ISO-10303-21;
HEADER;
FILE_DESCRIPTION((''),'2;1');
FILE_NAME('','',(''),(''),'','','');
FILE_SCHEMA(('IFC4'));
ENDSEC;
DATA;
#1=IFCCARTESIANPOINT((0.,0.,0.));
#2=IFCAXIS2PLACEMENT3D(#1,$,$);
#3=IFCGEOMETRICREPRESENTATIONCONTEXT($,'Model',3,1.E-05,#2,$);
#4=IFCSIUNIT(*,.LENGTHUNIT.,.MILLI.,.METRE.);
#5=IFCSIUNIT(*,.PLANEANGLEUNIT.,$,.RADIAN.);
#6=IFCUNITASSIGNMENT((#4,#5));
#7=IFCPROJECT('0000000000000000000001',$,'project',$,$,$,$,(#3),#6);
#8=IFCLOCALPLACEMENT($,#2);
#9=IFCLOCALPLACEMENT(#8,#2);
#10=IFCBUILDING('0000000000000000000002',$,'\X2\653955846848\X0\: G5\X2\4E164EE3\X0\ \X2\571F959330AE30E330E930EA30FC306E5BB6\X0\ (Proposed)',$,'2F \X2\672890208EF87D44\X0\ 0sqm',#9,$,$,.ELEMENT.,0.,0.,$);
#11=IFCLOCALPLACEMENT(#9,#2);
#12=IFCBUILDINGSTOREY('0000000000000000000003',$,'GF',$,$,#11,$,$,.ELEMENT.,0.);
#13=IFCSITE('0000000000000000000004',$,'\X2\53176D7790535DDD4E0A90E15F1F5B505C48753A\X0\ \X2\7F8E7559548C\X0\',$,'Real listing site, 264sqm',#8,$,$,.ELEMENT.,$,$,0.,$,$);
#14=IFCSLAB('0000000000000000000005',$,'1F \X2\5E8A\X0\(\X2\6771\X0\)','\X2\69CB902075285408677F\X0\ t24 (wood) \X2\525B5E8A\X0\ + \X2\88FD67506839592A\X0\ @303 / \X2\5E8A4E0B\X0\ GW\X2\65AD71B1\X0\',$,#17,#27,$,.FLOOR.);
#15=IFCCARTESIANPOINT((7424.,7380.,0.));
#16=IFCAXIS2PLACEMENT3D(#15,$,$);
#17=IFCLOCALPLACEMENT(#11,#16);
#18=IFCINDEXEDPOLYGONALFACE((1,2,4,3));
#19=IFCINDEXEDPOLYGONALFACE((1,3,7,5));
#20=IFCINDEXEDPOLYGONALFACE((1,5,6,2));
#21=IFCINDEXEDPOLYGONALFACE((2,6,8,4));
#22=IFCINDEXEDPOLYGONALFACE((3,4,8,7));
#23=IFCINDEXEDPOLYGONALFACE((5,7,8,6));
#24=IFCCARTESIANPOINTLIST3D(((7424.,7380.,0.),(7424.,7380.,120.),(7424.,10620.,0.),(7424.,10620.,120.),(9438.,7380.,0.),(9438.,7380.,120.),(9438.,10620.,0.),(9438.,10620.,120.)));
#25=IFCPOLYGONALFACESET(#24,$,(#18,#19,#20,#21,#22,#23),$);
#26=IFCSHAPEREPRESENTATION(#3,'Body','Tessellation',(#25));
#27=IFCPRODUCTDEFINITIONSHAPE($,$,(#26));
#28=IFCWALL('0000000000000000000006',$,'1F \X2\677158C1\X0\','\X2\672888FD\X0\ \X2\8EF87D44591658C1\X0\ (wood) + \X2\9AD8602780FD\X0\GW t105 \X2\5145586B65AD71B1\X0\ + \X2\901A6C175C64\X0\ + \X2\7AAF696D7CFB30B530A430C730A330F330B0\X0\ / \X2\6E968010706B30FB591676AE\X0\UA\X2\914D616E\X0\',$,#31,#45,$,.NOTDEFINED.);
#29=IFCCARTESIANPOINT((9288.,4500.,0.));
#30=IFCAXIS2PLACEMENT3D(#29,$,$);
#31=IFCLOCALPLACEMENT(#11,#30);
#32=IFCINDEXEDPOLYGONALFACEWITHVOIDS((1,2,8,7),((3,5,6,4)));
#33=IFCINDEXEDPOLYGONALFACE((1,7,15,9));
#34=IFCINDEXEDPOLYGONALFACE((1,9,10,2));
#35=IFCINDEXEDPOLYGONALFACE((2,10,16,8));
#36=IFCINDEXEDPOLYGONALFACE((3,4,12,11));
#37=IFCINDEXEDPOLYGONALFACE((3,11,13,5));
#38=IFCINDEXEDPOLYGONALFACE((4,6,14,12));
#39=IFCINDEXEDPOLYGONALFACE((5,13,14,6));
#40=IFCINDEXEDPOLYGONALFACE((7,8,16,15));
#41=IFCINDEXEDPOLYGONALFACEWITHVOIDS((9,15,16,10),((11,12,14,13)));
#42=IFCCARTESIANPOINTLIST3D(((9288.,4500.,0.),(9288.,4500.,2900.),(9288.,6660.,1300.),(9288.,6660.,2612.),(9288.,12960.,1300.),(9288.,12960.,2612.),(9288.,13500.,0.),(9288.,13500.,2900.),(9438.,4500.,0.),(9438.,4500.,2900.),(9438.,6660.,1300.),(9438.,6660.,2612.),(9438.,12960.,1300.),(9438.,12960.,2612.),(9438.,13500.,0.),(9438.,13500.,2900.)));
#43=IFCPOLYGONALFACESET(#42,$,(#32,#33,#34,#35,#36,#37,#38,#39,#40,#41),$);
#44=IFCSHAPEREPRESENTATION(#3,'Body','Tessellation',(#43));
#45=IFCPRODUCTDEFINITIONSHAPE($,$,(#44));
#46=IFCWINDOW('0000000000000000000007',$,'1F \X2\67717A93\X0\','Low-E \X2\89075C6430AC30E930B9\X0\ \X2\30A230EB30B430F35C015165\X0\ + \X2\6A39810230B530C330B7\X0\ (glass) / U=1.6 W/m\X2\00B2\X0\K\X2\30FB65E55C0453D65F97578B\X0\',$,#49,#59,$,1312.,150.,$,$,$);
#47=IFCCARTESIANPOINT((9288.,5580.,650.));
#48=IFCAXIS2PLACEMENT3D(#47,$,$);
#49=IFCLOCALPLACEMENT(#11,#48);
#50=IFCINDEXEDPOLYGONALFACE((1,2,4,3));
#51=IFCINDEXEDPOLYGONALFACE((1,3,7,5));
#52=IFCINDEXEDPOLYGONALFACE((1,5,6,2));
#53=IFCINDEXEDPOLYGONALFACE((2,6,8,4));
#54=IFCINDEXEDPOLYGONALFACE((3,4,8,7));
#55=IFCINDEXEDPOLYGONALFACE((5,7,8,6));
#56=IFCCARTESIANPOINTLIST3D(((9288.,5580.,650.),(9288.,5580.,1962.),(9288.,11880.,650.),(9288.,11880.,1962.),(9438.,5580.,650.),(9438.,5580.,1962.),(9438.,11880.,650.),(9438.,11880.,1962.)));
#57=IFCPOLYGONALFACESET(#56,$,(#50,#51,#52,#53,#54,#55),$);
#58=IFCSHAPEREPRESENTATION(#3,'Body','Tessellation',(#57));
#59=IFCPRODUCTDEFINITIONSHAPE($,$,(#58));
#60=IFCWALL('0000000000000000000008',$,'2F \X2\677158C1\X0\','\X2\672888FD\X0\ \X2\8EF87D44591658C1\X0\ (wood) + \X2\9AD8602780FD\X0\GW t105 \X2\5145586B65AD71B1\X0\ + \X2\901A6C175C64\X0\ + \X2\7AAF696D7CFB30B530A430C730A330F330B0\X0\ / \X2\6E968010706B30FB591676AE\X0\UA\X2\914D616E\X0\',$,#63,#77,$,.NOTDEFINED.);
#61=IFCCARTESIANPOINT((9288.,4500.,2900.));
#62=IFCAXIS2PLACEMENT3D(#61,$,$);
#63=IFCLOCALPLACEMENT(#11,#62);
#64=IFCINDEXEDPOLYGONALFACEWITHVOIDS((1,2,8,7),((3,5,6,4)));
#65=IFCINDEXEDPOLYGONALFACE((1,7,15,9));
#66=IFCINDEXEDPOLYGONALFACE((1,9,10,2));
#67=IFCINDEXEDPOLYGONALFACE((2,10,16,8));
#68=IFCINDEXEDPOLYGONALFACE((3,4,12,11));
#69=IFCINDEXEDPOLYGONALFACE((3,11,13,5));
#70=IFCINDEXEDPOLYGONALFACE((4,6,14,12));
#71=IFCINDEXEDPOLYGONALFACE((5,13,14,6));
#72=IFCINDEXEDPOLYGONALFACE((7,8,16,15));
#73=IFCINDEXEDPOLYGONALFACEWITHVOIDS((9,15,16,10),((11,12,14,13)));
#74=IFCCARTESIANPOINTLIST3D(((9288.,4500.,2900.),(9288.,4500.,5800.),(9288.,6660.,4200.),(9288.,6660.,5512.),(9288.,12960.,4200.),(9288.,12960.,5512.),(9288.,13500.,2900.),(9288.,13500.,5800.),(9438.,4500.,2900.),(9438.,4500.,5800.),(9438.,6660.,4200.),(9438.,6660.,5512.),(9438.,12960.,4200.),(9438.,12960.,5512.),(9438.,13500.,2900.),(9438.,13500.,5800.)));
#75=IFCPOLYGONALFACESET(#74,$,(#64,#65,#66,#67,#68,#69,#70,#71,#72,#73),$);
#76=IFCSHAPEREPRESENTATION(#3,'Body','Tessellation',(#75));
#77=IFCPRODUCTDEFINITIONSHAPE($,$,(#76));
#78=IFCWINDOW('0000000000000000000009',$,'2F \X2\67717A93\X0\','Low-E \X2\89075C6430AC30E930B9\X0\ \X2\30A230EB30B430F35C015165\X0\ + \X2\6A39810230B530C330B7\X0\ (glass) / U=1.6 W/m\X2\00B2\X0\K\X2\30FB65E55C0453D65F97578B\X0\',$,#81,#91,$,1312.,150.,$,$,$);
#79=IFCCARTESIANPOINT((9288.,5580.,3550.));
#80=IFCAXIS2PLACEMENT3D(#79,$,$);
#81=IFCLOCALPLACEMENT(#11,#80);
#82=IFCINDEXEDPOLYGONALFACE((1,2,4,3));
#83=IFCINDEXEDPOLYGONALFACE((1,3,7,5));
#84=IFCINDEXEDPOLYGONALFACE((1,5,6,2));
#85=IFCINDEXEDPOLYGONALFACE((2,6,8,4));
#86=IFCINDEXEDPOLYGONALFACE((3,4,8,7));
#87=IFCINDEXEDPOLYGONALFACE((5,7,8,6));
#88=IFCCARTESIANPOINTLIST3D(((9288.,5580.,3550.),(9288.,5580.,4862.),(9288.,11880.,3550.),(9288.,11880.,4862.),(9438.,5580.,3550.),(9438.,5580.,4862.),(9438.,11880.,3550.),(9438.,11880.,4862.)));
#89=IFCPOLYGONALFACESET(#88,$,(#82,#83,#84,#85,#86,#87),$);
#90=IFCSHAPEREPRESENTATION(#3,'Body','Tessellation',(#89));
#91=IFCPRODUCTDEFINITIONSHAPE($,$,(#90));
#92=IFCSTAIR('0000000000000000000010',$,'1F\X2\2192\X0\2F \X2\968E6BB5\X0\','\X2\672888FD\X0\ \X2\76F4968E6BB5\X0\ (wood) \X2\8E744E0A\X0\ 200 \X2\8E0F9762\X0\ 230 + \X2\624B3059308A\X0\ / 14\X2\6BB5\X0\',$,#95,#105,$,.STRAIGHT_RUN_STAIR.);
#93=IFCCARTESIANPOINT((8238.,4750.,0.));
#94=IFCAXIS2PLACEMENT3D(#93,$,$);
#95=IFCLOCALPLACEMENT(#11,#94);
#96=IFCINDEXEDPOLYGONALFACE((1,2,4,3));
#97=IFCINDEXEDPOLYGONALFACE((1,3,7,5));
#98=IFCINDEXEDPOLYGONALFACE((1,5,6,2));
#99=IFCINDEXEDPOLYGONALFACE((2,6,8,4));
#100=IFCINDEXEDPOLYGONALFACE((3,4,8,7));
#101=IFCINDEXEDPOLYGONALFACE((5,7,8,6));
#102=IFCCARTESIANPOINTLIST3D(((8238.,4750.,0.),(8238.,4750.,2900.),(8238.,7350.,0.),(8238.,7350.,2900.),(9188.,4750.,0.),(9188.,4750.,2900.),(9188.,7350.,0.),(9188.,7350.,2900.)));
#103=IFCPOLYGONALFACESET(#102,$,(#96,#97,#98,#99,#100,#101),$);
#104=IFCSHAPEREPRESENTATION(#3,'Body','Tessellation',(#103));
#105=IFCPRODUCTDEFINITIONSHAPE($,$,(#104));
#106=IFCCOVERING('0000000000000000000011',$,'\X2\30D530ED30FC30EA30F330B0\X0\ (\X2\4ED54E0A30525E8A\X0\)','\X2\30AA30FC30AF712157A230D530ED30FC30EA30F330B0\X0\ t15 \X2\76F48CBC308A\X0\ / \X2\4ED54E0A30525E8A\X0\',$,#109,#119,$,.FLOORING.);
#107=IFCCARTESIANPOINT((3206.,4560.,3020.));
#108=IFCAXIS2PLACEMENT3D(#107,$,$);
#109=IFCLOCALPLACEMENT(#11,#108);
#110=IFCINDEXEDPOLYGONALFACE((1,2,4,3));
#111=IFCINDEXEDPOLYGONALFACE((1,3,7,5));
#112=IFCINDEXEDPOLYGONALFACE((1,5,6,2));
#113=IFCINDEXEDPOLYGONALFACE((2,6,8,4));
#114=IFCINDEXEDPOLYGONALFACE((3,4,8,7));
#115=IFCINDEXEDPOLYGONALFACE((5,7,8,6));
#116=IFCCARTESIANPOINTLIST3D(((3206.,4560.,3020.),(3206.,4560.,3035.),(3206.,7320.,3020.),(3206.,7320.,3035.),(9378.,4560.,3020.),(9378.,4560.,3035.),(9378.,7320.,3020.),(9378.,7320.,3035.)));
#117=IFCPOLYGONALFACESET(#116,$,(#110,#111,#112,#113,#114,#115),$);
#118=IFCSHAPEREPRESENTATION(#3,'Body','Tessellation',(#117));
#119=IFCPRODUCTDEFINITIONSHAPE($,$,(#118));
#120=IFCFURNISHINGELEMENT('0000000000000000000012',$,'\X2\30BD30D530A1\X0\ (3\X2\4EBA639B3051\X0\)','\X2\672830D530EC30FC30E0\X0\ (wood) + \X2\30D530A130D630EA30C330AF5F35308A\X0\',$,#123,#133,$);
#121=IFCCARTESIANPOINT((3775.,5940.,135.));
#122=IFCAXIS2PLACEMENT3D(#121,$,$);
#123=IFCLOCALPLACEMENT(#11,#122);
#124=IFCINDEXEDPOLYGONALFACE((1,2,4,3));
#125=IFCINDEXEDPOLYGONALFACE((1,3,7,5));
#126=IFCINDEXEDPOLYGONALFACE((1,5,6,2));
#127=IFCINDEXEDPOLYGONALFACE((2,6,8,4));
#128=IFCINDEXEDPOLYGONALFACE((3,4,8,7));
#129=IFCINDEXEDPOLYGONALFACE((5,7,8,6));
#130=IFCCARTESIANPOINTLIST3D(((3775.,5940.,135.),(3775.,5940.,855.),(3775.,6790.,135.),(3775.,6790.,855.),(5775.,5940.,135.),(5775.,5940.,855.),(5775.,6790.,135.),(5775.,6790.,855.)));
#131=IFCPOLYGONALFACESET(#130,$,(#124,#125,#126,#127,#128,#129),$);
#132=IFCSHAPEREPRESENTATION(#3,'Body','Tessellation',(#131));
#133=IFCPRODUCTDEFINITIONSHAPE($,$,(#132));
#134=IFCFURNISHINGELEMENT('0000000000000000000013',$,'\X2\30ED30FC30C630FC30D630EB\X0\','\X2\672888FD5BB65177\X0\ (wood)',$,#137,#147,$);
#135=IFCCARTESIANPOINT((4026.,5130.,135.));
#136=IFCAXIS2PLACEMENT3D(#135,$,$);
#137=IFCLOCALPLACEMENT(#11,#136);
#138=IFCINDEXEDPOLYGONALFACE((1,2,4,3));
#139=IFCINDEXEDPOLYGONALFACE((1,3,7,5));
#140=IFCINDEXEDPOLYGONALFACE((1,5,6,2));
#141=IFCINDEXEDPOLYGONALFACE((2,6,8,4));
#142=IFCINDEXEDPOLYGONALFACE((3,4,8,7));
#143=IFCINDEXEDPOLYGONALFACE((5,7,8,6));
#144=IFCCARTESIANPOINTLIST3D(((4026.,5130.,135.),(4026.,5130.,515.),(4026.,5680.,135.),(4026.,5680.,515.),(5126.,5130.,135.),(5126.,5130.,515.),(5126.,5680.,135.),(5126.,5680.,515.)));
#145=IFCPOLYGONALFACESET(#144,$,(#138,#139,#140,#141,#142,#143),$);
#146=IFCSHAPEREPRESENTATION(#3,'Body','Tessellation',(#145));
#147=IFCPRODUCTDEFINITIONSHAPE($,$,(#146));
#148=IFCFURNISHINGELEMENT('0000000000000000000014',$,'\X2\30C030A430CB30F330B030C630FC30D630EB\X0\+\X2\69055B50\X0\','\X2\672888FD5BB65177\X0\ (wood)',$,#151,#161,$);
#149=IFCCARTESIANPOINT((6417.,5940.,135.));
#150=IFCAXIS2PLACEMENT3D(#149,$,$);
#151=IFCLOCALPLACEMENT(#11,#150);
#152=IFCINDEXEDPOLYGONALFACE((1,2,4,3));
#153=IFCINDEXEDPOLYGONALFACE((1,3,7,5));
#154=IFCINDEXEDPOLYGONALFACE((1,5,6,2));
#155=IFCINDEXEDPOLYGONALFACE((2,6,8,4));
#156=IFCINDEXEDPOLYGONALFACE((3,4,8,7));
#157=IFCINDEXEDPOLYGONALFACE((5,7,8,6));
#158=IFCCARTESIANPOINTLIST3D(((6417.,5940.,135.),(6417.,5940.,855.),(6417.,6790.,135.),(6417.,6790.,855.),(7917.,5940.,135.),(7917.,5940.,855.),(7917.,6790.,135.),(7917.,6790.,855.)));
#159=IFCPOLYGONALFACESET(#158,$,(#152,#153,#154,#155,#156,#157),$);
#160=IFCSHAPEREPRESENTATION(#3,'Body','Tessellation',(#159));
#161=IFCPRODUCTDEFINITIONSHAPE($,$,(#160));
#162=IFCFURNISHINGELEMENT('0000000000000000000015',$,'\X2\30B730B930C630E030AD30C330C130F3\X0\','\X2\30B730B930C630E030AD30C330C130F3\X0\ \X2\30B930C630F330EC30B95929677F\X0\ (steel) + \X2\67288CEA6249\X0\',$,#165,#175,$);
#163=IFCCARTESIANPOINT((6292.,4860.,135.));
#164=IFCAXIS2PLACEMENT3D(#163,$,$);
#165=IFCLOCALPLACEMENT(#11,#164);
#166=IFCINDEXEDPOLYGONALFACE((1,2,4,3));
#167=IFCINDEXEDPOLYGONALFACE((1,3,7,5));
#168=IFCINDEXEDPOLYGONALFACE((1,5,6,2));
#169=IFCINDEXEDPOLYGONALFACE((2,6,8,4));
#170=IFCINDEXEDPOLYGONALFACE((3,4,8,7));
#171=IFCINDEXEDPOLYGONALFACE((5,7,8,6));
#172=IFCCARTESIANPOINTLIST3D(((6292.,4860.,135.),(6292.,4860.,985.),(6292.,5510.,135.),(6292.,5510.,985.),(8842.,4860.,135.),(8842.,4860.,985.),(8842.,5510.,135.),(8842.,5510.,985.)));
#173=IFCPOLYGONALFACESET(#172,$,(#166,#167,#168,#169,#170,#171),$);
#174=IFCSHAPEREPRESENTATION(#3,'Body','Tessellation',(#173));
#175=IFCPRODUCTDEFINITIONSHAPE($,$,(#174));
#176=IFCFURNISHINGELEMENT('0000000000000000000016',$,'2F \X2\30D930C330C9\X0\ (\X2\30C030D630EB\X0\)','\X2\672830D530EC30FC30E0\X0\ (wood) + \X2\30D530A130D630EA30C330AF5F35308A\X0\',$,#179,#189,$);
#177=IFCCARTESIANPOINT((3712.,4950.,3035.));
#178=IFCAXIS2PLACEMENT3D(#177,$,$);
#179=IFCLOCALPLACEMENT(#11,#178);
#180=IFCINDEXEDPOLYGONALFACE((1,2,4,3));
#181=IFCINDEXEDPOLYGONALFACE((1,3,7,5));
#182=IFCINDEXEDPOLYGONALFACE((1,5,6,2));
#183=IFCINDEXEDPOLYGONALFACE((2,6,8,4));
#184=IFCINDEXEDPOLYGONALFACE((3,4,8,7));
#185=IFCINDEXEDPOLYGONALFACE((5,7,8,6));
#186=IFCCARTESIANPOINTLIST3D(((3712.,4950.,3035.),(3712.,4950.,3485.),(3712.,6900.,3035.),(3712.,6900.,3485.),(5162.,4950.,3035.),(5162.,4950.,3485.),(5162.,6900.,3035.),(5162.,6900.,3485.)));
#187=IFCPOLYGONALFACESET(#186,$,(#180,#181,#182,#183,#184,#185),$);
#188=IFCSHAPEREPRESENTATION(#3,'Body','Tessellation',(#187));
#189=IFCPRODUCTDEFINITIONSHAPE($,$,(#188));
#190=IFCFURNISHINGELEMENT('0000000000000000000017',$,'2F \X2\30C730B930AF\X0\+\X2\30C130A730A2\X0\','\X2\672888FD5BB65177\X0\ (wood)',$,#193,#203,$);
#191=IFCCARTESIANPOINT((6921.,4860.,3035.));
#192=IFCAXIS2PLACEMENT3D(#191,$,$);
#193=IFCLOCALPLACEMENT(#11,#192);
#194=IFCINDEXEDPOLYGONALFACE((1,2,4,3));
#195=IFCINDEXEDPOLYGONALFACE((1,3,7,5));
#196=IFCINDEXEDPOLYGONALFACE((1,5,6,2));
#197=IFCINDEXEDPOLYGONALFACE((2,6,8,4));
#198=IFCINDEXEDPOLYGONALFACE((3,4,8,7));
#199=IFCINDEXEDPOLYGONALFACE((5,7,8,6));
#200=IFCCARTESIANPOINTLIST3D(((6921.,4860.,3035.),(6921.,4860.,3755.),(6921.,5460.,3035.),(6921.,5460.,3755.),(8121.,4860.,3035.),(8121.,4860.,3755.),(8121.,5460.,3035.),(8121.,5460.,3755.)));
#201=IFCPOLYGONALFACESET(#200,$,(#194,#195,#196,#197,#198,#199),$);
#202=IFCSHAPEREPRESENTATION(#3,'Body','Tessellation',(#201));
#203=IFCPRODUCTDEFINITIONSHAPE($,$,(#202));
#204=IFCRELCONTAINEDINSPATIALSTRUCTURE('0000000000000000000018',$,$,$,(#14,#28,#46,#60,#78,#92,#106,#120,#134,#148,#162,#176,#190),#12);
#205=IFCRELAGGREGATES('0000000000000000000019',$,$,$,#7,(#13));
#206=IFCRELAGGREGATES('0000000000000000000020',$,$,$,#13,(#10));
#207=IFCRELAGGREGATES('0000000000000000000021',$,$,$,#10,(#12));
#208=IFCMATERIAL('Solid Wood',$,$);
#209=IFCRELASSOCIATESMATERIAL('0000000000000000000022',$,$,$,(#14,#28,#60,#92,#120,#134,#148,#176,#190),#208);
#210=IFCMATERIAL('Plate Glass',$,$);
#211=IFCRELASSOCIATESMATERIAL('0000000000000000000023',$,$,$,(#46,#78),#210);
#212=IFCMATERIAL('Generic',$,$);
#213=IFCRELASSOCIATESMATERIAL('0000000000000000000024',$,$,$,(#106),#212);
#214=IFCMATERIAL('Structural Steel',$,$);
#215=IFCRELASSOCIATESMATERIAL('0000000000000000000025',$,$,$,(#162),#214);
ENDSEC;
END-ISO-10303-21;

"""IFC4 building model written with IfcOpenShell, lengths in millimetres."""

from ifc_helpers import new_model, si_unit, frame, frame_2d, origin, place, context, project, spatial, rectangle, extrude, material, element, fill, save


model = new_model("IFC4")

# Units and contexts
model_context = context("Model", 3, precision=1e-05, world=origin())
ifc_project = project(units=[si_unit("LENGTHUNIT", "METRE", prefix="MILLI"), si_unit("PLANEANGLEUNIT", "RADIAN")], contexts=[model_context])

# Site, building, storey
site_placement = place(None, origin())
site = spatial("IfcSite", under=ifc_project, at=site_placement, Name="北海道川上郡弟子屈町 美留和", ObjectType="Real listing site, 264sqm", CompositionType="ELEMENT", RefElevation=0.0)
building_placement = place(site_placement, origin())
building = spatial("IfcBuilding", under=site, at=building_placement, Name="改善案: G5世代 土間ギャラリーの家 (Proposed)", ObjectType="2F 木造軸組 0sqm", CompositionType="ELEMENT", ElevationOfRefHeight=0.0, ElevationOfTerrain=0.0)
storey_placement = place(building_placement, origin())
storey = spatial("IfcBuildingStorey", under=building, at=storey_placement, Name="GF", CompositionType="ELEMENT", Elevation=0.0)

# Slab
ifc_material_1 = material(Name="Solid Wood")
slab_placement = place(storey_placement, frame((7424.0, 7380.0, 0.0)))
element("IfcSlab", 1, at=slab_placement, inside=storey, material=ifc_material_1, Name="1F 床(東)", Description="構造用合板 t24 (wood) 剛床 + 製材根太 @303 / 床下 GW断熱", PredefinedType="FLOOR", context=model_context, shape_type="SweptSolid", body=[
    extrude(rectangle(XDim=2014.0, YDim=3240.0, at=frame_2d((1007.0, 1620.0))), frame((7424.0, 7380.0, 0.0)), (0.0, 0.0, 1.0), 120.0),
])

# Wall, opening, window
wall_1_placement = place(storey_placement, frame((9288.0, 4500.0, 0.0)))
wall_1 = element("IfcWall", 2, at=wall_1_placement, inside=storey, material=ifc_material_1, Name="1F 東壁", Description="木製 軸組外壁 (wood) + 高性能GW t105 充填断熱 + 通気層 + 窯業系サイディング / 準耐火・外皮UA配慮", PredefinedType="NOTDEFINED", context=model_context, shape_type="SweptSolid", body=[
    extrude(rectangle(XDim=150.0, YDim=9000.0, at=frame_2d((75.0, 4500.0))), frame((9288.0, 4500.0, 0.0)), (0.0, 0.0, 1.0), 2900.0),
])
opening_1_placement = place(storey_placement, frame((9288.0, 5580.0, 650.0)))
opening_1 = element("IfcOpeningElement", 3, at=opening_1_placement, cuts=wall_1, PredefinedType="NOTDEFINED", context=model_context, shape_type="SweptSolid", body=[
    extrude(rectangle(XDim=150.0, YDim=6300.0, at=frame_2d((75.0, 3150.0))), frame((9288.0, 5580.0, 650.0)), (0.0, 0.0, 1.0), 1312.0),
])
ifc_material_2 = material(Name="Plate Glass")
window_1_placement = place(storey_placement, frame((9288.0, 5580.0, 650.0)))
window_1 = element("IfcWindow", 4, at=window_1_placement, inside=storey, material=ifc_material_2, Name="1F 東窓", Description="Low-E 複層ガラス アルゴン封入 + 樹脂サッシ (glass) / U=1.6 W/m²K・日射取得型", OverallHeight=1312.0, OverallWidth=150.0, context=model_context, shape_type="SweptSolid", body=[
    extrude(rectangle(XDim=150.0, YDim=6300.0, at=frame_2d((75.0, 3150.0))), frame((9288.0, 5580.0, 650.0)), (0.0, 0.0, 1.0), 1312.0),
])
fill(opening_1, window_1)

# Wall, opening, window
wall_2_placement = place(storey_placement, frame((9288.0, 4500.0, 2900.0)))
wall_2 = element("IfcWall", 5, at=wall_2_placement, inside=storey, material=ifc_material_1, Name="2F 東壁", Description="木製 軸組外壁 (wood) + 高性能GW t105 充填断熱 + 通気層 + 窯業系サイディング / 準耐火・外皮UA配慮", PredefinedType="NOTDEFINED", context=model_context, shape_type="SweptSolid", body=[
    extrude(rectangle(XDim=150.0, YDim=9000.0, at=frame_2d((75.0, 4500.0))), frame((9288.0, 4500.0, 2900.0)), (0.0, 0.0, 1.0), 2900.0),
])
opening_2_placement = place(storey_placement, frame((9288.0, 5580.0, 3550.0)))
opening_2 = element("IfcOpeningElement", 6, at=opening_2_placement, cuts=wall_2, PredefinedType="NOTDEFINED", context=model_context, shape_type="SweptSolid", body=[
    extrude(rectangle(XDim=150.0, YDim=6300.0, at=frame_2d((75.0, 3150.0))), frame((9288.0, 5580.0, 3550.0)), (0.0, 0.0, 1.0), 1312.0),
])
window_2_placement = place(storey_placement, frame((9288.0, 5580.0, 3550.0)))
window_2 = element("IfcWindow", 7, at=window_2_placement, inside=storey, material=ifc_material_2, Name="2F 東窓", Description="Low-E 複層ガラス アルゴン封入 + 樹脂サッシ (glass) / U=1.6 W/m²K・日射取得型", OverallHeight=1312.0, OverallWidth=150.0, context=model_context, shape_type="SweptSolid", body=[
    extrude(rectangle(XDim=150.0, YDim=6300.0, at=frame_2d((75.0, 3150.0))), frame((9288.0, 5580.0, 3550.0)), (0.0, 0.0, 1.0), 1312.0),
])
fill(opening_2, window_2)

# Stair
stair_placement = place(storey_placement, frame((8238.0, 4750.0, 0.0)))
element("IfcStair", 8, at=stair_placement, inside=storey, material=ifc_material_1, Name="1F→2F 階段", Description="木製 直階段 (wood) 蹴上 200 踏面 230 + 手すり / 14段", PredefinedType="STRAIGHT_RUN_STAIR", context=model_context, shape_type="SweptSolid", body=[
    extrude(rectangle(XDim=950.0, YDim=2600.0, at=frame_2d((475.0, 1300.0))), frame((8238.0, 4750.0, 0.0)), (0.0, 0.0, 1.0), 2900.0),
])

# Covering
ifc_material_3 = material(Name="Generic")
covering_placement = place(storey_placement, frame((3206.0, 4560.0, 3020.0)))
element("IfcCovering", 9, at=covering_placement, inside=storey, material=ifc_material_3, Name="フローリング (仕上げ床)", Description="オーク無垢フローリング t15 直貼り / 仕上げ床", PredefinedType="FLOORING", context=model_context, shape_type="SweptSolid", body=[
    extrude(rectangle(XDim=6172.0, YDim=2760.0, at=frame_2d((3086.0, 1380.0))), frame((3206.0, 4560.0, 3020.0)), (0.0, 0.0, 1.0), 15.0),
])

# Furnishing elements
furnishing_1_placement = place(storey_placement, frame((3775.0, 5940.0, 135.0)))
element("IfcFurnishingElement", 10, at=furnishing_1_placement, inside=storey, material=ifc_material_1, Name="ソファ (3人掛け)", Description="木フレーム (wood) + ファブリック張り", context=model_context, shape_type="SweptSolid", body=[
    extrude(rectangle(XDim=2000.0, YDim=850.0, at=frame_2d((1000.0, 425.0))), frame((3775.0, 5940.0, 135.0)), (0.0, 0.0, 1.0), 720.0),
])
furnishing_2_placement = place(storey_placement, frame((4026.0, 5130.0, 135.0)))
element("IfcFurnishingElement", 11, at=furnishing_2_placement, inside=storey, material=ifc_material_1, Name="ローテーブル", Description="木製家具 (wood)", context=model_context, shape_type="SweptSolid", body=[
    extrude(rectangle(XDim=1100.0, YDim=550.0, at=frame_2d((550.0, 275.0))), frame((4026.0, 5130.0, 135.0)), (0.0, 0.0, 1.0), 380.0),
])
furnishing_3_placement = place(storey_placement, frame((6417.0, 5940.0, 135.0)))
element("IfcFurnishingElement", 12, at=furnishing_3_placement, inside=storey, material=ifc_material_1, Name="ダイニングテーブル+椅子", Description="木製家具 (wood)", context=model_context, shape_type="SweptSolid", body=[
    extrude(rectangle(XDim=1500.0, YDim=850.0, at=frame_2d((750.0, 425.0))), frame((6417.0, 5940.0, 135.0)), (0.0, 0.0, 1.0), 720.0),
])
ifc_material_4 = material(Name="Structural Steel")
furnishing_4_placement = place(storey_placement, frame((6292.0, 4860.0, 135.0)))
element("IfcFurnishingElement", 13, at=furnishing_4_placement, inside=storey, material=ifc_material_4, Name="システムキッチン", Description="システムキッチン ステンレス天板 (steel) + 木質扉", context=model_context, shape_type="SweptSolid", body=[
    extrude(rectangle(XDim=2550.0, YDim=650.0, at=frame_2d((1275.0, 325.0))), frame((6292.0, 4860.0, 135.0)), (0.0, 0.0, 1.0), 850.0),
])
furnishing_5_placement = place(storey_placement, frame((3712.0, 4950.0, 3035.0)))
element("IfcFurnishingElement", 14, at=furnishing_5_placement, inside=storey, material=ifc_material_1, Name="2F ベッド (ダブル)", Description="木フレーム (wood) + ファブリック張り", context=model_context, shape_type="SweptSolid", body=[
    extrude(rectangle(XDim=1450.0, YDim=1950.0, at=frame_2d((725.0, 975.0))), frame((3712.0, 4950.0, 3035.0)), (0.0, 0.0, 1.0), 450.0),
])
furnishing_6_placement = place(storey_placement, frame((6921.0, 4860.0, 3035.0)))
element("IfcFurnishingElement", 15, at=furnishing_6_placement, inside=storey, material=ifc_material_1, Name="2F デスク+チェア", Description="木製家具 (wood)", context=model_context, shape_type="SweptSolid", body=[
    extrude(rectangle(XDim=1200.0, YDim=600.0, at=frame_2d((600.0, 300.0))), frame((6921.0, 4860.0, 3035.0)), (0.0, 0.0, 1.0), 720.0),
])

save(model, "model.ifc")
